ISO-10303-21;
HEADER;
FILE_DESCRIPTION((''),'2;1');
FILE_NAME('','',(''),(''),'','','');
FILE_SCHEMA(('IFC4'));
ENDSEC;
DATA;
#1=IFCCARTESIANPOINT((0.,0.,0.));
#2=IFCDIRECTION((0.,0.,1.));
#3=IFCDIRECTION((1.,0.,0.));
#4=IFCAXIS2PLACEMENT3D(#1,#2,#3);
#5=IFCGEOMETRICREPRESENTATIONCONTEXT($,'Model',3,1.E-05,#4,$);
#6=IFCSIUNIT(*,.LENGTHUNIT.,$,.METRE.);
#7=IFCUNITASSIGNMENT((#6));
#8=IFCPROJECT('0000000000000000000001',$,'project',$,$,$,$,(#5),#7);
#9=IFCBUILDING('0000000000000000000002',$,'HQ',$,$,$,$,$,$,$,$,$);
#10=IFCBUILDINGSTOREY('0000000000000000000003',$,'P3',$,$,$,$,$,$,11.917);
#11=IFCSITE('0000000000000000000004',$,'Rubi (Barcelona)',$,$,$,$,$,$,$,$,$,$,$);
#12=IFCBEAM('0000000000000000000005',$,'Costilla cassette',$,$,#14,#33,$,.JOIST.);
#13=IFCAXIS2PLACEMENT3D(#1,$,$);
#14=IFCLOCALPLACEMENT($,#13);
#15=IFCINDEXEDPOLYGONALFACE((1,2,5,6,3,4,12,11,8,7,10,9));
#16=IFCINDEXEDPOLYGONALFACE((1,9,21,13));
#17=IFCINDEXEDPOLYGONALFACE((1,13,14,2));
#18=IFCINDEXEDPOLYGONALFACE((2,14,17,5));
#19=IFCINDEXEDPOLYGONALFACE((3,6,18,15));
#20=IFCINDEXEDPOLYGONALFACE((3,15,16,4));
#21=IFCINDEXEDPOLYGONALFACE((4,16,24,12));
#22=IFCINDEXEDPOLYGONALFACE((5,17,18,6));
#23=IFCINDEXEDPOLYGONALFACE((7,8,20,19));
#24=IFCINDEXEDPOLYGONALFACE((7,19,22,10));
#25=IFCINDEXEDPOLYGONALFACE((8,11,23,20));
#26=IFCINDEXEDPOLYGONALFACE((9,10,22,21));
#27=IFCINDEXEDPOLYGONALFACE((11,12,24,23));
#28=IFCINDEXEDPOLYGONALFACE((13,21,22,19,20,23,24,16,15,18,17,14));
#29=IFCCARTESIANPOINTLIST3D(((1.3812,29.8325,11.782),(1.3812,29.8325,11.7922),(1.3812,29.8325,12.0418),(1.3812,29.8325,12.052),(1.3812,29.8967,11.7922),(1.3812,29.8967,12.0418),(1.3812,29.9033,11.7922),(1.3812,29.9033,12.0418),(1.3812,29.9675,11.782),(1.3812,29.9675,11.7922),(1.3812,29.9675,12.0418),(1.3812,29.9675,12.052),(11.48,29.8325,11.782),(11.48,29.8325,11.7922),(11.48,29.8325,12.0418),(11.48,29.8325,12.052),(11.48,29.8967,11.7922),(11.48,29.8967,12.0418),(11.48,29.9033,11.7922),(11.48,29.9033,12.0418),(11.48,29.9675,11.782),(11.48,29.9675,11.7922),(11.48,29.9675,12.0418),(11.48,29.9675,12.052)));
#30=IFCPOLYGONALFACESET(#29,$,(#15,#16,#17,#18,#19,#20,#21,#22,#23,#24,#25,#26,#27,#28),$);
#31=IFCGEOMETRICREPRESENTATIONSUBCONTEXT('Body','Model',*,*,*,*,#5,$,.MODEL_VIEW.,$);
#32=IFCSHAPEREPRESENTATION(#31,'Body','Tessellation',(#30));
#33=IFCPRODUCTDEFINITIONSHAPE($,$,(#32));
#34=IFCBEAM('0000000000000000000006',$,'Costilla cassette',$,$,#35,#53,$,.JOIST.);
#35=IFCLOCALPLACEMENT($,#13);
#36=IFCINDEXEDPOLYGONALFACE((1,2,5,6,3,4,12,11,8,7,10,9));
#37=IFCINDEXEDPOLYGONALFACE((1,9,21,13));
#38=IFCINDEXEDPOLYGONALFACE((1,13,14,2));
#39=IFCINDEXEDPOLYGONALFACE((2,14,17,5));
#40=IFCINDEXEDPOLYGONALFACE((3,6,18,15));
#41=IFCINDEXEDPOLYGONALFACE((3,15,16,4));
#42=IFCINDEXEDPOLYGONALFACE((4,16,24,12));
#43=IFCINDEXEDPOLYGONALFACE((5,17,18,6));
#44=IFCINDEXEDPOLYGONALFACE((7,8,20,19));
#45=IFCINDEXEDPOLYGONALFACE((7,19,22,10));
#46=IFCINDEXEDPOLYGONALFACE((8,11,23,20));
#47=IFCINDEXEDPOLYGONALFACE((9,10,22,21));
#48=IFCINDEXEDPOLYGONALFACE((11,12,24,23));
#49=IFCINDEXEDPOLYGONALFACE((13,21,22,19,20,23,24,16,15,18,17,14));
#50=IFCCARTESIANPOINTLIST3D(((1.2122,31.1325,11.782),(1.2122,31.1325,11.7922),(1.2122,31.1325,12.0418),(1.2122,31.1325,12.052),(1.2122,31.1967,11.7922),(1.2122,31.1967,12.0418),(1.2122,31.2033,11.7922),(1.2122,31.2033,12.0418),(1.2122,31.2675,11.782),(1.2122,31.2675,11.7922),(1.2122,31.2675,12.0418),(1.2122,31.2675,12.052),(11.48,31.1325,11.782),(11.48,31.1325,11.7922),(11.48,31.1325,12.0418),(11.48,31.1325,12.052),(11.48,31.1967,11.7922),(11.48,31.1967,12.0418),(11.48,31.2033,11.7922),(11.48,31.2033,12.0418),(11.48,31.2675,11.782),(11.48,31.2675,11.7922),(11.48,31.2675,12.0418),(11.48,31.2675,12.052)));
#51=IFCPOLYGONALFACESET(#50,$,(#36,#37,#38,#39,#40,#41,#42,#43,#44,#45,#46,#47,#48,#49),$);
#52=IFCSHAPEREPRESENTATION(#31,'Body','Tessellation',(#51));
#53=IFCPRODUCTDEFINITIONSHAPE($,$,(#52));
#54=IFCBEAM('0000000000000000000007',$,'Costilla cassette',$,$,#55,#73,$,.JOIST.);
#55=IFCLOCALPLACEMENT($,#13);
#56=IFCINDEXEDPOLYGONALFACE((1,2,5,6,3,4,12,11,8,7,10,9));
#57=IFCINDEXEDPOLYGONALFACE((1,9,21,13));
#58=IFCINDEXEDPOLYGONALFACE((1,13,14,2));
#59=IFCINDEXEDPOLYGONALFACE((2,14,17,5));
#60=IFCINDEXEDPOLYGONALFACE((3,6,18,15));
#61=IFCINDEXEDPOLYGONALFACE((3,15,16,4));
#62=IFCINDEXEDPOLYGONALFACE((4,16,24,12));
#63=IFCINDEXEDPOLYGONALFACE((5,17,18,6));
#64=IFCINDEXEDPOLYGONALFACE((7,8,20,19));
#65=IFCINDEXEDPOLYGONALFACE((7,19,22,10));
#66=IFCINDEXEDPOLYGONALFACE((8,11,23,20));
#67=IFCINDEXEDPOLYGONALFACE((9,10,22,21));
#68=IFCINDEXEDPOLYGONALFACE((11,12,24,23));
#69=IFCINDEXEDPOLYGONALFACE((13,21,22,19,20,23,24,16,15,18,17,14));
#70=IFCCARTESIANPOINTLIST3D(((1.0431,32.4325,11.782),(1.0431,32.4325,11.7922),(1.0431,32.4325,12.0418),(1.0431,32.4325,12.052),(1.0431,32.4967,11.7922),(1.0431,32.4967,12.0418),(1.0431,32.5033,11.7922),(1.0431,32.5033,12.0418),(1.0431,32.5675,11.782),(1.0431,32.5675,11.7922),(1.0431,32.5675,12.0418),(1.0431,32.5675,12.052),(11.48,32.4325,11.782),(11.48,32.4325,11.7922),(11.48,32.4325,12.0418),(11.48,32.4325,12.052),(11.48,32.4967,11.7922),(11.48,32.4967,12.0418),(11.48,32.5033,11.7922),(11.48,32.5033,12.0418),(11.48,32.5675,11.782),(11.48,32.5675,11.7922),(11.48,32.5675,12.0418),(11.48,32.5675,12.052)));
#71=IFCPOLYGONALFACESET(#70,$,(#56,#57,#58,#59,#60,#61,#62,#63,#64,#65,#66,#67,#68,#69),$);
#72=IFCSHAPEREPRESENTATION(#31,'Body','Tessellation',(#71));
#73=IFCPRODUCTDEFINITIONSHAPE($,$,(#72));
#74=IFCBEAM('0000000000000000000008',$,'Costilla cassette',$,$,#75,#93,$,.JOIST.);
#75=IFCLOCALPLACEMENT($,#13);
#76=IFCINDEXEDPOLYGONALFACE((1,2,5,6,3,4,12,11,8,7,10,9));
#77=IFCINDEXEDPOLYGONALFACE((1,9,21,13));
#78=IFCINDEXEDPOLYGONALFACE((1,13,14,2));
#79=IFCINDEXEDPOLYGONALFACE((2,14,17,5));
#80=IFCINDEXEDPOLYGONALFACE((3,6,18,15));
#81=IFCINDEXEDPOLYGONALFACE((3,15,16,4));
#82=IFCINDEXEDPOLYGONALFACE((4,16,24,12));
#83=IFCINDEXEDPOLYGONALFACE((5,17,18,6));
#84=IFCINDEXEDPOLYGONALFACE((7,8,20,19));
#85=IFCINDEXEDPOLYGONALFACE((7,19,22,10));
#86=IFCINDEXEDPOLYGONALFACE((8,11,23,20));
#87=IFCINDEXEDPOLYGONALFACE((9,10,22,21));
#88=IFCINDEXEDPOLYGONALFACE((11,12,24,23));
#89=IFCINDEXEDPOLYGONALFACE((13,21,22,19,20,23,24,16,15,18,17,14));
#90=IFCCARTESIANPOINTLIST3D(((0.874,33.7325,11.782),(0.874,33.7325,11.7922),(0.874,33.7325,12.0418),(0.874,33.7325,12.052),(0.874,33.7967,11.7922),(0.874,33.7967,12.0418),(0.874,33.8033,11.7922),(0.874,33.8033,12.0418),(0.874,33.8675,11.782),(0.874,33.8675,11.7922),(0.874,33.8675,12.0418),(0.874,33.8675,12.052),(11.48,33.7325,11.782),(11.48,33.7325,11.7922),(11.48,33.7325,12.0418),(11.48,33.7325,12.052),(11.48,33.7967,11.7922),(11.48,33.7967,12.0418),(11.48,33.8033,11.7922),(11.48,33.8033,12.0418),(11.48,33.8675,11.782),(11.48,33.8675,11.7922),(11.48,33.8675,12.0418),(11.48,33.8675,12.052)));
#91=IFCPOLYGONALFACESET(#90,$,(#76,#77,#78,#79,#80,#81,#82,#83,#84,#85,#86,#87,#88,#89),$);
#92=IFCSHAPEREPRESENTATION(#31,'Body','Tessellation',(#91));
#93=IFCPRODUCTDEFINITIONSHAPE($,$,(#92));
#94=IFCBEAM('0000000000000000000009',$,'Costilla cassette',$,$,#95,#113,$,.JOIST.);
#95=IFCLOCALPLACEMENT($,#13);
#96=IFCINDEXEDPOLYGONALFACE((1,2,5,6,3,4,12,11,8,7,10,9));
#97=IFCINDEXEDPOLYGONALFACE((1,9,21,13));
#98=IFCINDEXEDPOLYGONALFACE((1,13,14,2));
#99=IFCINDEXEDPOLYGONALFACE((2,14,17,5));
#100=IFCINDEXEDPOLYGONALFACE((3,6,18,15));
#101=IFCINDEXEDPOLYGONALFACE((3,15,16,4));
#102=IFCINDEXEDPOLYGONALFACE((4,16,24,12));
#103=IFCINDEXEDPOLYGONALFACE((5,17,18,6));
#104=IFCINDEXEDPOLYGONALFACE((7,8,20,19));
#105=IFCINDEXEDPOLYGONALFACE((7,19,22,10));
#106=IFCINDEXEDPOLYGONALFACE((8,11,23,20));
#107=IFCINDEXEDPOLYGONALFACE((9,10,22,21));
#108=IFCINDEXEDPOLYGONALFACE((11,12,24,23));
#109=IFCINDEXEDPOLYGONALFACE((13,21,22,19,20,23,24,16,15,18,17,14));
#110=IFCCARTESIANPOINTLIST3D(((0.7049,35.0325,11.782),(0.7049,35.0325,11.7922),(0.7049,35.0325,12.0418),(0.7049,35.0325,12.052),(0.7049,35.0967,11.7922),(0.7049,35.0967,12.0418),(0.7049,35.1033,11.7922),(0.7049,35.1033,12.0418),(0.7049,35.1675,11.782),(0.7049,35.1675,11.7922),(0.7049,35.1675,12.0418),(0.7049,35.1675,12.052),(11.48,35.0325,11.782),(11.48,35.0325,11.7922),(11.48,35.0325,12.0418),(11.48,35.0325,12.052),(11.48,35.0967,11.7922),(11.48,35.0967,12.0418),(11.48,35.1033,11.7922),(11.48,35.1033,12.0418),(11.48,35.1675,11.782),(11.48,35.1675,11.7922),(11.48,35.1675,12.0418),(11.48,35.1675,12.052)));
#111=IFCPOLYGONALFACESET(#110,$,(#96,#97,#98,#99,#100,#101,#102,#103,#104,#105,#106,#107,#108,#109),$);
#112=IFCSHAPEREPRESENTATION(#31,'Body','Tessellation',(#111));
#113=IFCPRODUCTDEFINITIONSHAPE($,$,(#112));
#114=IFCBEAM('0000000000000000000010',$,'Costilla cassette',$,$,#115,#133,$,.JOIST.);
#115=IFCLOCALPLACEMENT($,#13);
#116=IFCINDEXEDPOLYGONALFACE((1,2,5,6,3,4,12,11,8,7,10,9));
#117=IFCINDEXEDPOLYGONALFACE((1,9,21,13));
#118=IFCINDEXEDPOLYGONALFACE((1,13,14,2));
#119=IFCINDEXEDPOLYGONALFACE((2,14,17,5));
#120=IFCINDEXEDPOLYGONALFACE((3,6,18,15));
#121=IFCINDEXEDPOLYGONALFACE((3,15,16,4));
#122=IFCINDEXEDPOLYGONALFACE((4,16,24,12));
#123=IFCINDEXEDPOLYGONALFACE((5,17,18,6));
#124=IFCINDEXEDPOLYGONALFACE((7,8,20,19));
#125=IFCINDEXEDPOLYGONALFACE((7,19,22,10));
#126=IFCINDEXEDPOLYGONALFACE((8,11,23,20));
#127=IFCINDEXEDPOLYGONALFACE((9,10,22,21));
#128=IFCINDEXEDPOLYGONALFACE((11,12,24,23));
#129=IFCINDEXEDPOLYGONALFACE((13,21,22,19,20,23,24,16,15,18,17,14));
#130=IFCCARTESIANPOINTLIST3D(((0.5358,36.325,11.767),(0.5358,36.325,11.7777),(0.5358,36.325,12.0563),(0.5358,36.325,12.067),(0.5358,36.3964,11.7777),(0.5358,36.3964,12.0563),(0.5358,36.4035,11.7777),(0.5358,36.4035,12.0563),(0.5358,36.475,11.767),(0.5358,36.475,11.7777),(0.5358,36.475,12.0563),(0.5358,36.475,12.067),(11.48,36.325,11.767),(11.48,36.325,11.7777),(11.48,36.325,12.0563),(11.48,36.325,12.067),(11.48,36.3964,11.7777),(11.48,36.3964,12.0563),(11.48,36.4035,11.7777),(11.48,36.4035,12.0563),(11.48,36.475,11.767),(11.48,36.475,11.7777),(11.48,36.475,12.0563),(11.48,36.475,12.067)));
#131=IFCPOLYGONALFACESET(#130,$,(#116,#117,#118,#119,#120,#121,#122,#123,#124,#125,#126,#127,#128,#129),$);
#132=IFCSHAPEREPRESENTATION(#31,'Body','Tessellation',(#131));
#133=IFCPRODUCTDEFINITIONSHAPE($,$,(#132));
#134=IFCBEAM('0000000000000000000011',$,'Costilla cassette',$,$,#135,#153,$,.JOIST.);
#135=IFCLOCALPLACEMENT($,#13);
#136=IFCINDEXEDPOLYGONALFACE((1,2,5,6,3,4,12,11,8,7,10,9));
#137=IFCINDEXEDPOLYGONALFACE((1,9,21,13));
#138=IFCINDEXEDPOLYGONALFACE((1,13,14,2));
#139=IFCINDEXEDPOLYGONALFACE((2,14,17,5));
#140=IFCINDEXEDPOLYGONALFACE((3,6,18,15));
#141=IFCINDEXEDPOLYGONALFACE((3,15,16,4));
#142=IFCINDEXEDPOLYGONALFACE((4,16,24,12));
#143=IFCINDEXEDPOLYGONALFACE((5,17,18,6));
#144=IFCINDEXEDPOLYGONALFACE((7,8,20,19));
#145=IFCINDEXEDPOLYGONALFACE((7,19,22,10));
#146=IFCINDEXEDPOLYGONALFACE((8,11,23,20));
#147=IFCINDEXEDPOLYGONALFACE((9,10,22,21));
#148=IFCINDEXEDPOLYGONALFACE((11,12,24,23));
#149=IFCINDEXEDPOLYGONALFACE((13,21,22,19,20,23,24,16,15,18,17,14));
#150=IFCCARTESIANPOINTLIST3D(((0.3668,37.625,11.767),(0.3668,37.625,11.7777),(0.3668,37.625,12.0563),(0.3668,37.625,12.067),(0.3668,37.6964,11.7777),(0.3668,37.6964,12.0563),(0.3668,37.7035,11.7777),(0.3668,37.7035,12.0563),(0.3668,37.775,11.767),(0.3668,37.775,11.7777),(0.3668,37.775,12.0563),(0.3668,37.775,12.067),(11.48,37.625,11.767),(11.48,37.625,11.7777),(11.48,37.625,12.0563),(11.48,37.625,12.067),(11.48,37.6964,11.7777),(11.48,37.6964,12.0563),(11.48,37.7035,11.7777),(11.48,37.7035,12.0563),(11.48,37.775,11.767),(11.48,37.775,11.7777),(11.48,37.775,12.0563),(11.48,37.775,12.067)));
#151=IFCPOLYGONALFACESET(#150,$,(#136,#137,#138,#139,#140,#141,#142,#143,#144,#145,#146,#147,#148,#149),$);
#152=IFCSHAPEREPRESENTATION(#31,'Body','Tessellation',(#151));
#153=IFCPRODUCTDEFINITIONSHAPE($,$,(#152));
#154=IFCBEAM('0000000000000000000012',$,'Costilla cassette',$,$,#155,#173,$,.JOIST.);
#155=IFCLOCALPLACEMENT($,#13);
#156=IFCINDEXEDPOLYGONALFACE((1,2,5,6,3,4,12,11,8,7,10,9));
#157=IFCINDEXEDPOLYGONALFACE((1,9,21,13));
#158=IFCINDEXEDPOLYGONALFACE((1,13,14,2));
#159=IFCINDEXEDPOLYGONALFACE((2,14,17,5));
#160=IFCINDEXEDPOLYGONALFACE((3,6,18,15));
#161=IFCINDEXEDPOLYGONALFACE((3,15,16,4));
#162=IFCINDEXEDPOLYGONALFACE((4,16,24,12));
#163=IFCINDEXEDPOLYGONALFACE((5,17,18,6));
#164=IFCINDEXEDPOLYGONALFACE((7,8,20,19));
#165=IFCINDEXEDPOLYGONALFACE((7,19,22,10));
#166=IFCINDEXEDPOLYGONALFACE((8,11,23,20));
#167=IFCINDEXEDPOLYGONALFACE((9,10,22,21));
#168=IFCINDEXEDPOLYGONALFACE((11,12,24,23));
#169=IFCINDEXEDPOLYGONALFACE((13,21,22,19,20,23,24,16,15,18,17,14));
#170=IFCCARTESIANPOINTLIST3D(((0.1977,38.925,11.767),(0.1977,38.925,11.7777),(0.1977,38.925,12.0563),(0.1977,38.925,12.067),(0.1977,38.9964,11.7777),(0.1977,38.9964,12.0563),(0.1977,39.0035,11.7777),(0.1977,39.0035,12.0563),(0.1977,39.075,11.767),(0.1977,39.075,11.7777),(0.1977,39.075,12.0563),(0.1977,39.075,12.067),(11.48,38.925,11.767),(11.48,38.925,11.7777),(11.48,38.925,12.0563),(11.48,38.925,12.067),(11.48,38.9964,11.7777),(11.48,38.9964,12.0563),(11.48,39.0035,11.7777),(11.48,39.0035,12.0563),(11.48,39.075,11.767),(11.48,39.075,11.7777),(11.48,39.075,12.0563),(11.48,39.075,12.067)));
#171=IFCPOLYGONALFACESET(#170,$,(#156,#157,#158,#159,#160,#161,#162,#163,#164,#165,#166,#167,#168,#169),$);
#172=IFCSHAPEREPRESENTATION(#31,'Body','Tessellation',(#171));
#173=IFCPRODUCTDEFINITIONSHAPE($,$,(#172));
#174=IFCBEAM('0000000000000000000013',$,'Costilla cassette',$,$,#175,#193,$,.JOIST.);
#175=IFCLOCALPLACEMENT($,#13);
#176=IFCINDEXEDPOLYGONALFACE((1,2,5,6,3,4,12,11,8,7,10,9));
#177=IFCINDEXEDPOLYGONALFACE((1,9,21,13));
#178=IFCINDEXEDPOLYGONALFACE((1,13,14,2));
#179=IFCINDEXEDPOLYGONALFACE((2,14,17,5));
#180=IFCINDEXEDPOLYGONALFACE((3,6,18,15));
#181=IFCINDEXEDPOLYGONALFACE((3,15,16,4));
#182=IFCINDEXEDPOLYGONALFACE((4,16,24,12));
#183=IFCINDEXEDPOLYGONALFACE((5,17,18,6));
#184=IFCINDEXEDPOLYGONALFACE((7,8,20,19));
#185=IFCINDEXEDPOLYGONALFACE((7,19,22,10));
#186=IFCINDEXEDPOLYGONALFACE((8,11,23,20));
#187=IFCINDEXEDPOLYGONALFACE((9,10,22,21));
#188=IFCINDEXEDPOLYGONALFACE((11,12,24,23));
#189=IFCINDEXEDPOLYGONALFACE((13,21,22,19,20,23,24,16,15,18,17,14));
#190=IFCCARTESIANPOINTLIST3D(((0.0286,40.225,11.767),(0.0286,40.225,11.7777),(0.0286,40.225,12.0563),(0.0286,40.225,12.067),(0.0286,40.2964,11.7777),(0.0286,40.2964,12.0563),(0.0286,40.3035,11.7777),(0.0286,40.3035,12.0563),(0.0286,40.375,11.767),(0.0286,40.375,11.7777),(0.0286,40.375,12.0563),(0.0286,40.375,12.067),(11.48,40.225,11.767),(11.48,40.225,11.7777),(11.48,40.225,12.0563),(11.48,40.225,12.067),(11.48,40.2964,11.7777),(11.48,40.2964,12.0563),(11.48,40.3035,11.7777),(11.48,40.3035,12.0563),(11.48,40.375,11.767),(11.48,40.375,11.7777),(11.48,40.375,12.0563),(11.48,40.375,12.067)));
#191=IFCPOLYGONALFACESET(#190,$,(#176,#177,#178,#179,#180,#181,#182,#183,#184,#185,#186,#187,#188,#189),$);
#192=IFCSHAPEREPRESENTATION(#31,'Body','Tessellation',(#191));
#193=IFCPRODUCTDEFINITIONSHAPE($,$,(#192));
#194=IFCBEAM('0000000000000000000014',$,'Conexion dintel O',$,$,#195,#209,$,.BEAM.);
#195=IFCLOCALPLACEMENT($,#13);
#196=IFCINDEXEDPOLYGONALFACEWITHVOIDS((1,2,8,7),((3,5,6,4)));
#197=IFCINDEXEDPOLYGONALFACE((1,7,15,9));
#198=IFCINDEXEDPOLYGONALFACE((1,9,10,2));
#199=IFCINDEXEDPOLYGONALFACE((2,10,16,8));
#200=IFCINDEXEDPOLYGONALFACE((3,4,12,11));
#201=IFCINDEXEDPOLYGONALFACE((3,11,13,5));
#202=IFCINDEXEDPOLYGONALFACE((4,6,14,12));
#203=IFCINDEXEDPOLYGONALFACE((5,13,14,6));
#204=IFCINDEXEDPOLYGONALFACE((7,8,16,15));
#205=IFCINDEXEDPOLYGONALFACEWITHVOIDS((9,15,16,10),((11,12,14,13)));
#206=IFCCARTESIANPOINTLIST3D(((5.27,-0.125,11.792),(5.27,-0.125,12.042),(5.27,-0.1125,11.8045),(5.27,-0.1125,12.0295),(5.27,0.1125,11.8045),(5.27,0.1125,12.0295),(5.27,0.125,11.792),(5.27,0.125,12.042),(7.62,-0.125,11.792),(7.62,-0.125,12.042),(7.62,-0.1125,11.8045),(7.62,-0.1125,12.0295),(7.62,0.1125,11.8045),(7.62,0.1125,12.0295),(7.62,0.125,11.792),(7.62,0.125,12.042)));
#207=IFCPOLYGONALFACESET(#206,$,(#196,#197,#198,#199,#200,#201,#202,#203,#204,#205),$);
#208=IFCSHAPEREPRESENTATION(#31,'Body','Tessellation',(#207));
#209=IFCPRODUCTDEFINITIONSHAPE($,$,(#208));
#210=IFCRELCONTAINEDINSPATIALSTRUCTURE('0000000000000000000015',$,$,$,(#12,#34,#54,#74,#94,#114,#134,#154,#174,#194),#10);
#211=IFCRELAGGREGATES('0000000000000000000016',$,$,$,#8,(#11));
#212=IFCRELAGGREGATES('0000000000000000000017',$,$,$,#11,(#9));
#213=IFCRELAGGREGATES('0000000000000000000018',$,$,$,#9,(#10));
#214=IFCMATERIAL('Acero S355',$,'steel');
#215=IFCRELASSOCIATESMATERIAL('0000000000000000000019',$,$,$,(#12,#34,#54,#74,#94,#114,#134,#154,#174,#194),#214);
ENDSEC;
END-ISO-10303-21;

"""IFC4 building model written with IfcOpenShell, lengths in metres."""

from ifc_helpers import new_model, si_unit, frame, origin_with_axes, place, context, subcontext, project, spatial, hollow_rectangle, i_section, extrude, material, element, save


model = new_model("IFC4")

# Units and contexts
model_context = context("Model", 3, precision=1e-05, world=origin_with_axes())
body_context = subcontext(model_context, "Body", "Model", "MODEL_VIEW")
ifc_project = project(units=[si_unit("LENGTHUNIT", "METRE")], contexts=[model_context])

# Site, building, storey
site = spatial("IfcSite", under=ifc_project, Name="Rubi (Barcelona)")
building = spatial("IfcBuilding", under=site, Name="HQ")
storey = spatial("IfcBuildingStorey", under=building, Name="P3", Elevation=11.917)

# Beams
ifc_material_1 = material(Name="Acero S355", Category="steel")
beam_1_placement = place(None, origin_with_axes())
element("IfcBeam", 1, at=beam_1_placement, inside=storey, material=ifc_material_1, Name="Costilla cassette", PredefinedType="JOIST", context=body_context, shape_type="SweptSolid", body=[
    extrude(i_section(OverallWidth=0.135, OverallDepth=0.27, WebThickness=0.0066, FlangeThickness=0.0102), frame((1.3812, 29.9, 11.917), z_axis=(1.0, 0.0, 0.0), x_axis=(0.0, 1.0, 0.0)), (0.0, 0.0, 1.0), 10.0988),
])
beam_2_placement = place(None, origin_with_axes())
element("IfcBeam", 2, at=beam_2_placement, inside=storey, material=ifc_material_1, Name="Costilla cassette", PredefinedType="JOIST", context=body_context, shape_type="SweptSolid", body=[
    extrude(i_section(OverallWidth=0.135, OverallDepth=0.27, WebThickness=0.0066, FlangeThickness=0.0102), frame((1.2122, 31.2, 11.917), z_axis=(1.0, 0.0, 0.0), x_axis=(0.0, 1.0, 0.0)), (0.0, 0.0, 1.0), 10.2678),
])
beam_3_placement = place(None, origin_with_axes())
element("IfcBeam", 3, at=beam_3_placement, inside=storey, material=ifc_material_1, Name="Costilla cassette", PredefinedType="JOIST", context=body_context, shape_type="SweptSolid", body=[
    extrude(i_section(OverallWidth=0.135, OverallDepth=0.27, WebThickness=0.0066, FlangeThickness=0.0102), frame((1.0431, 32.5, 11.917), z_axis=(1.0, 0.0, 0.0), x_axis=(0.0, 1.0, 0.0)), (0.0, 0.0, 1.0), 10.4369),
])
beam_4_placement = place(None, origin_with_axes())
element("IfcBeam", 4, at=beam_4_placement, inside=storey, material=ifc_material_1, Name="Costilla cassette", PredefinedType="JOIST", context=body_context, shape_type="SweptSolid", body=[
    extrude(i_section(OverallWidth=0.135, OverallDepth=0.27, WebThickness=0.0066, FlangeThickness=0.0102), frame((0.874, 33.8, 11.917), z_axis=(1.0, 0.0, 0.0), x_axis=(0.0, 1.0, 0.0)), (0.0, 0.0, 1.0), 10.606),
])
beam_5_placement = place(None, origin_with_axes())
element("IfcBeam", 5, at=beam_5_placement, inside=storey, material=ifc_material_1, Name="Costilla cassette", PredefinedType="JOIST", context=body_context, shape_type="SweptSolid", body=[
    extrude(i_section(OverallWidth=0.135, OverallDepth=0.27, WebThickness=0.0066, FlangeThickness=0.0102), frame((0.7049, 35.1, 11.917), z_axis=(1.0, 0.0, 0.0), x_axis=(0.0, 1.0, 0.0)), (0.0, 0.0, 1.0), 10.7751),
])
beam_6_placement = place(None, origin_with_axes())
element("IfcBeam", 6, at=beam_6_placement, inside=storey, material=ifc_material_1, Name="Costilla cassette", PredefinedType="JOIST", context=body_context, shape_type="SweptSolid", body=[
    extrude(i_section(OverallWidth=0.15, OverallDepth=0.3, WebThickness=0.0071, FlangeThickness=0.0107), frame((0.5358, 36.4, 11.917), z_axis=(1.0, 0.0, 0.0), x_axis=(0.0, 1.0, 0.0)), (0.0, 0.0, 1.0), 10.9442),
])
beam_7_placement = place(None, origin_with_axes())
element("IfcBeam", 7, at=beam_7_placement, inside=storey, material=ifc_material_1, Name="Costilla cassette", PredefinedType="JOIST", context=body_context, shape_type="SweptSolid", body=[
    extrude(i_section(OverallWidth=0.15, OverallDepth=0.3, WebThickness=0.0071, FlangeThickness=0.0107), frame((0.3668, 37.7, 11.917), z_axis=(1.0, 0.0, 0.0), x_axis=(0.0, 1.0, 0.0)), (0.0, 0.0, 1.0), 11.1132),
])
beam_8_placement = place(None, origin_with_axes())
element("IfcBeam", 8, at=beam_8_placement, inside=storey, material=ifc_material_1, Name="Costilla cassette", PredefinedType="JOIST", context=body_context, shape_type="SweptSolid", body=[
    extrude(i_section(OverallWidth=0.15, OverallDepth=0.3, WebThickness=0.0071, FlangeThickness=0.0107), frame((0.1977, 39.0, 11.917), z_axis=(1.0, 0.0, 0.0), x_axis=(0.0, 1.0, 0.0)), (0.0, 0.0, 1.0), 11.2823),
])
beam_9_placement = place(None, origin_with_axes())
element("IfcBeam", 9, at=beam_9_placement, inside=storey, material=ifc_material_1, Name="Costilla cassette", PredefinedType="JOIST", context=body_context, shape_type="SweptSolid", body=[
    extrude(i_section(OverallWidth=0.15, OverallDepth=0.3, WebThickness=0.0071, FlangeThickness=0.0107), frame((0.0286, 40.3, 11.917), z_axis=(1.0, 0.0, 0.0), x_axis=(0.0, 1.0, 0.0)), (0.0, 0.0, 1.0), 11.4514),
])
beam_10_placement = place(None, origin_with_axes())
element("IfcBeam", 10, at=beam_10_placement, inside=storey, material=ifc_material_1, Name="Conexion dintel O", PredefinedType="BEAM", context=body_context, shape_type="SweptSolid", body=[
    extrude(hollow_rectangle(XDim=0.25, YDim=0.25, WallThickness=0.0125), frame((5.27, 0.0, 11.917), z_axis=(1.0, 0.0, 0.0), x_axis=(0.0, 1.0, 0.0)), (0.0, 0.0, 1.0), 2.35),
])

save(model, "model.ifc")
